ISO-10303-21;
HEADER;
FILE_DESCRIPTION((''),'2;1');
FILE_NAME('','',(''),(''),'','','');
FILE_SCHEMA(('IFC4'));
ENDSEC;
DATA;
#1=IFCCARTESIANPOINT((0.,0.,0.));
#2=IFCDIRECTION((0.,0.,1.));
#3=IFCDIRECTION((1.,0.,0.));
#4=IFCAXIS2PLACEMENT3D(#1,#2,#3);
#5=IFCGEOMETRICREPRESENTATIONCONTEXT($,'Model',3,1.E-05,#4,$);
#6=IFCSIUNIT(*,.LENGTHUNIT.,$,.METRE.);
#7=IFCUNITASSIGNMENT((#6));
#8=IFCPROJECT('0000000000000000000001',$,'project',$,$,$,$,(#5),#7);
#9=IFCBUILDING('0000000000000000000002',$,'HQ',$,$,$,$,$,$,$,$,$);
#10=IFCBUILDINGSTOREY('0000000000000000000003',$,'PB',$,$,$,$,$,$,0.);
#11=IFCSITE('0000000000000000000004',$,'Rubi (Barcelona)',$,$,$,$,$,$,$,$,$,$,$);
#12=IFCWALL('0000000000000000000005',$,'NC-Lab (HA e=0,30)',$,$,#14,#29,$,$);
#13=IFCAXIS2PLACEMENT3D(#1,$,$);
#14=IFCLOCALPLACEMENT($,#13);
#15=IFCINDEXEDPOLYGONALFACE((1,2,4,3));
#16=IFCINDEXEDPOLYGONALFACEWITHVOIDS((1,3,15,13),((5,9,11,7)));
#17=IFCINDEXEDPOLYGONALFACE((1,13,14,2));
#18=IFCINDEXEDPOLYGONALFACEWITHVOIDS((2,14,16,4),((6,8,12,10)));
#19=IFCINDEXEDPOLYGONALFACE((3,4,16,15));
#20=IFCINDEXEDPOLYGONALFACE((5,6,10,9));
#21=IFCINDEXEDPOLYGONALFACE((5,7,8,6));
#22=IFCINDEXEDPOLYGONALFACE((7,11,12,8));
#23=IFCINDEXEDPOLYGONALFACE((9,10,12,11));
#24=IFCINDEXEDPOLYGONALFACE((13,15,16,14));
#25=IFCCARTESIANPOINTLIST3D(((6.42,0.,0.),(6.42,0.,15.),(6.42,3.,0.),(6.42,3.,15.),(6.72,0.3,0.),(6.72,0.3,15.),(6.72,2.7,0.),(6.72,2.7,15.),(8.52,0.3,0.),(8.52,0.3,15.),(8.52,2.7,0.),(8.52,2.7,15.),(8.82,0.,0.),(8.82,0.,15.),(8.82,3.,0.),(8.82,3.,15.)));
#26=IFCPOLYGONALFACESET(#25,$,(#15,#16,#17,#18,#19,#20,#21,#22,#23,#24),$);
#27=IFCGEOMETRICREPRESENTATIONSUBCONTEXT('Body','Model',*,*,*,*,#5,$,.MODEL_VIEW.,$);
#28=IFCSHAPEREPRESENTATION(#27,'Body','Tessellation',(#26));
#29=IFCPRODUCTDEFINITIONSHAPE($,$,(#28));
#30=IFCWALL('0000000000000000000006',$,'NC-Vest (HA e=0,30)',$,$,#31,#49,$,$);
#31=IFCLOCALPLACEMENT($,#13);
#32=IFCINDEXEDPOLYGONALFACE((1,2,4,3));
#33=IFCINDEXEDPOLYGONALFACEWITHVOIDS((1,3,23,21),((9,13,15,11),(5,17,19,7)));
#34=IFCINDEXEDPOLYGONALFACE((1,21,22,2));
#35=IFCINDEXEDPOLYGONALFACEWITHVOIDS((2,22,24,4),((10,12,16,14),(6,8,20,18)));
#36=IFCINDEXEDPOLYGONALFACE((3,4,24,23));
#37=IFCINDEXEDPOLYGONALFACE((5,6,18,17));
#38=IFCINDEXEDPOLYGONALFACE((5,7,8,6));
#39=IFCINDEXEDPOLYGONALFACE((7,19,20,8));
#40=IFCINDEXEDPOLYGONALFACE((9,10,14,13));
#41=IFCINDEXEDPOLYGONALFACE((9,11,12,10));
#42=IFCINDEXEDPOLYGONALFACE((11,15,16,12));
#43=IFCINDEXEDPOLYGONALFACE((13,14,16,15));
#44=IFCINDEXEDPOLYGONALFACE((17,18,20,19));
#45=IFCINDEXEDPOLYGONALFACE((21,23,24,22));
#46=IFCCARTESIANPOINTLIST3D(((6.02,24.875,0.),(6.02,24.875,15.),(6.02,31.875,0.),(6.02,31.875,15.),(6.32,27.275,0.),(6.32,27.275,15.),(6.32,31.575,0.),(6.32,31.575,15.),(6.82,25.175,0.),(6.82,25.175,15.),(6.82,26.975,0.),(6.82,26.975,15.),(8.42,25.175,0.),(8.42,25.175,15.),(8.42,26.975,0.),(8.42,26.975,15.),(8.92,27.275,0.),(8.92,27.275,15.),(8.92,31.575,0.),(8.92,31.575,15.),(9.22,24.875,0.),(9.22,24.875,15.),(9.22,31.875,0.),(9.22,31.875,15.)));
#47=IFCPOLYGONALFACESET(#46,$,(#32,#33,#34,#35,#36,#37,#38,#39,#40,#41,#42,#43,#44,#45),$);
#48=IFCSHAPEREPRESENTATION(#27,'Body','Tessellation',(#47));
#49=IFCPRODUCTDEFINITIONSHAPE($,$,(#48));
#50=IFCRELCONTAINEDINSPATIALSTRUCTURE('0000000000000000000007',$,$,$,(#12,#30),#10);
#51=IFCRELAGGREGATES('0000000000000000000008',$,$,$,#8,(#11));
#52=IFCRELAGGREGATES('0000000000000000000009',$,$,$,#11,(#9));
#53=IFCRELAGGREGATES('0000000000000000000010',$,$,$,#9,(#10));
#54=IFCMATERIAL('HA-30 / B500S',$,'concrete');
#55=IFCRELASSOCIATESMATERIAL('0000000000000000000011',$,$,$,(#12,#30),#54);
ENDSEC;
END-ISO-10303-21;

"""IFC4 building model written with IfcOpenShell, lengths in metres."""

from ifc_helpers import new_model, si_unit, origin, origin_with_axes, place, context, subcontext, project, spatial, polyline, outline, extrude, material, element, save


model = new_model("IFC4")

# Units and contexts
model_context = context("Model", 3, precision=1e-05, world=origin_with_axes())
body_context = subcontext(model_context, "Body", "Model", "MODEL_VIEW")
ifc_project = project(units=[si_unit("LENGTHUNIT", "METRE")], contexts=[model_context])

# Site, building, storey
site = spatial("IfcSite", under=ifc_project, Name="Rubi (Barcelona)")
building = spatial("IfcBuilding", under=site, Name="HQ")
storey = spatial("IfcBuildingStorey", under=building, Name="PB", Elevation=0.0)

# Walls
ifc_material = material(Name="HA-30 / B500S", Category="concrete")
wall_1_placement = place(None, origin_with_axes())
element("IfcWall", 1, at=wall_1_placement, inside=storey, material=ifc_material, Name="NC-Lab (HA e=0,30)", context=body_context, shape_type="SweptSolid", body=[
    extrude(outline(polyline([(6.42, 0.0, 0.0), (8.82, 0.0, 0.0), (8.82, 3.0, 0.0), (6.42, 3.0, 0.0), (6.42, 0.0, 0.0)]), holes=[polyline([(6.72, 0.3, 0.0), (8.52, 0.3, 0.0), (8.52, 2.7, 0.0), (6.72, 2.7, 0.0), (6.72, 0.3, 0.0)])]), origin(), (0.0, 0.0, 1.0), 15.0),
])
wall_2_placement = place(None, origin_with_axes())
element("IfcWall", 2, at=wall_2_placement, inside=storey, material=ifc_material, Name="NC-Vest (HA e=0,30)", context=body_context, shape_type="SweptSolid", body=[
    extrude(outline(polyline([(6.02, 24.875, 0.0), (9.22, 24.875, 0.0), (9.22, 31.875, 0.0), (6.02, 31.875, 0.0), (6.02, 24.875, 0.0)]), holes=[polyline([(6.82, 25.175, 0.0), (8.42, 25.175, 0.0), (8.42, 26.975, 0.0), (6.82, 26.975, 0.0), (6.82, 25.175, 0.0)]), polyline([(6.32, 27.275, 0.0), (8.92, 27.275, 0.0), (8.92, 31.575, 0.0), (6.32, 31.575, 0.0), (6.32, 27.275, 0.0)])]), origin(), (0.0, 0.0, 1.0), 15.0),
])

save(model, "model.ifc")
